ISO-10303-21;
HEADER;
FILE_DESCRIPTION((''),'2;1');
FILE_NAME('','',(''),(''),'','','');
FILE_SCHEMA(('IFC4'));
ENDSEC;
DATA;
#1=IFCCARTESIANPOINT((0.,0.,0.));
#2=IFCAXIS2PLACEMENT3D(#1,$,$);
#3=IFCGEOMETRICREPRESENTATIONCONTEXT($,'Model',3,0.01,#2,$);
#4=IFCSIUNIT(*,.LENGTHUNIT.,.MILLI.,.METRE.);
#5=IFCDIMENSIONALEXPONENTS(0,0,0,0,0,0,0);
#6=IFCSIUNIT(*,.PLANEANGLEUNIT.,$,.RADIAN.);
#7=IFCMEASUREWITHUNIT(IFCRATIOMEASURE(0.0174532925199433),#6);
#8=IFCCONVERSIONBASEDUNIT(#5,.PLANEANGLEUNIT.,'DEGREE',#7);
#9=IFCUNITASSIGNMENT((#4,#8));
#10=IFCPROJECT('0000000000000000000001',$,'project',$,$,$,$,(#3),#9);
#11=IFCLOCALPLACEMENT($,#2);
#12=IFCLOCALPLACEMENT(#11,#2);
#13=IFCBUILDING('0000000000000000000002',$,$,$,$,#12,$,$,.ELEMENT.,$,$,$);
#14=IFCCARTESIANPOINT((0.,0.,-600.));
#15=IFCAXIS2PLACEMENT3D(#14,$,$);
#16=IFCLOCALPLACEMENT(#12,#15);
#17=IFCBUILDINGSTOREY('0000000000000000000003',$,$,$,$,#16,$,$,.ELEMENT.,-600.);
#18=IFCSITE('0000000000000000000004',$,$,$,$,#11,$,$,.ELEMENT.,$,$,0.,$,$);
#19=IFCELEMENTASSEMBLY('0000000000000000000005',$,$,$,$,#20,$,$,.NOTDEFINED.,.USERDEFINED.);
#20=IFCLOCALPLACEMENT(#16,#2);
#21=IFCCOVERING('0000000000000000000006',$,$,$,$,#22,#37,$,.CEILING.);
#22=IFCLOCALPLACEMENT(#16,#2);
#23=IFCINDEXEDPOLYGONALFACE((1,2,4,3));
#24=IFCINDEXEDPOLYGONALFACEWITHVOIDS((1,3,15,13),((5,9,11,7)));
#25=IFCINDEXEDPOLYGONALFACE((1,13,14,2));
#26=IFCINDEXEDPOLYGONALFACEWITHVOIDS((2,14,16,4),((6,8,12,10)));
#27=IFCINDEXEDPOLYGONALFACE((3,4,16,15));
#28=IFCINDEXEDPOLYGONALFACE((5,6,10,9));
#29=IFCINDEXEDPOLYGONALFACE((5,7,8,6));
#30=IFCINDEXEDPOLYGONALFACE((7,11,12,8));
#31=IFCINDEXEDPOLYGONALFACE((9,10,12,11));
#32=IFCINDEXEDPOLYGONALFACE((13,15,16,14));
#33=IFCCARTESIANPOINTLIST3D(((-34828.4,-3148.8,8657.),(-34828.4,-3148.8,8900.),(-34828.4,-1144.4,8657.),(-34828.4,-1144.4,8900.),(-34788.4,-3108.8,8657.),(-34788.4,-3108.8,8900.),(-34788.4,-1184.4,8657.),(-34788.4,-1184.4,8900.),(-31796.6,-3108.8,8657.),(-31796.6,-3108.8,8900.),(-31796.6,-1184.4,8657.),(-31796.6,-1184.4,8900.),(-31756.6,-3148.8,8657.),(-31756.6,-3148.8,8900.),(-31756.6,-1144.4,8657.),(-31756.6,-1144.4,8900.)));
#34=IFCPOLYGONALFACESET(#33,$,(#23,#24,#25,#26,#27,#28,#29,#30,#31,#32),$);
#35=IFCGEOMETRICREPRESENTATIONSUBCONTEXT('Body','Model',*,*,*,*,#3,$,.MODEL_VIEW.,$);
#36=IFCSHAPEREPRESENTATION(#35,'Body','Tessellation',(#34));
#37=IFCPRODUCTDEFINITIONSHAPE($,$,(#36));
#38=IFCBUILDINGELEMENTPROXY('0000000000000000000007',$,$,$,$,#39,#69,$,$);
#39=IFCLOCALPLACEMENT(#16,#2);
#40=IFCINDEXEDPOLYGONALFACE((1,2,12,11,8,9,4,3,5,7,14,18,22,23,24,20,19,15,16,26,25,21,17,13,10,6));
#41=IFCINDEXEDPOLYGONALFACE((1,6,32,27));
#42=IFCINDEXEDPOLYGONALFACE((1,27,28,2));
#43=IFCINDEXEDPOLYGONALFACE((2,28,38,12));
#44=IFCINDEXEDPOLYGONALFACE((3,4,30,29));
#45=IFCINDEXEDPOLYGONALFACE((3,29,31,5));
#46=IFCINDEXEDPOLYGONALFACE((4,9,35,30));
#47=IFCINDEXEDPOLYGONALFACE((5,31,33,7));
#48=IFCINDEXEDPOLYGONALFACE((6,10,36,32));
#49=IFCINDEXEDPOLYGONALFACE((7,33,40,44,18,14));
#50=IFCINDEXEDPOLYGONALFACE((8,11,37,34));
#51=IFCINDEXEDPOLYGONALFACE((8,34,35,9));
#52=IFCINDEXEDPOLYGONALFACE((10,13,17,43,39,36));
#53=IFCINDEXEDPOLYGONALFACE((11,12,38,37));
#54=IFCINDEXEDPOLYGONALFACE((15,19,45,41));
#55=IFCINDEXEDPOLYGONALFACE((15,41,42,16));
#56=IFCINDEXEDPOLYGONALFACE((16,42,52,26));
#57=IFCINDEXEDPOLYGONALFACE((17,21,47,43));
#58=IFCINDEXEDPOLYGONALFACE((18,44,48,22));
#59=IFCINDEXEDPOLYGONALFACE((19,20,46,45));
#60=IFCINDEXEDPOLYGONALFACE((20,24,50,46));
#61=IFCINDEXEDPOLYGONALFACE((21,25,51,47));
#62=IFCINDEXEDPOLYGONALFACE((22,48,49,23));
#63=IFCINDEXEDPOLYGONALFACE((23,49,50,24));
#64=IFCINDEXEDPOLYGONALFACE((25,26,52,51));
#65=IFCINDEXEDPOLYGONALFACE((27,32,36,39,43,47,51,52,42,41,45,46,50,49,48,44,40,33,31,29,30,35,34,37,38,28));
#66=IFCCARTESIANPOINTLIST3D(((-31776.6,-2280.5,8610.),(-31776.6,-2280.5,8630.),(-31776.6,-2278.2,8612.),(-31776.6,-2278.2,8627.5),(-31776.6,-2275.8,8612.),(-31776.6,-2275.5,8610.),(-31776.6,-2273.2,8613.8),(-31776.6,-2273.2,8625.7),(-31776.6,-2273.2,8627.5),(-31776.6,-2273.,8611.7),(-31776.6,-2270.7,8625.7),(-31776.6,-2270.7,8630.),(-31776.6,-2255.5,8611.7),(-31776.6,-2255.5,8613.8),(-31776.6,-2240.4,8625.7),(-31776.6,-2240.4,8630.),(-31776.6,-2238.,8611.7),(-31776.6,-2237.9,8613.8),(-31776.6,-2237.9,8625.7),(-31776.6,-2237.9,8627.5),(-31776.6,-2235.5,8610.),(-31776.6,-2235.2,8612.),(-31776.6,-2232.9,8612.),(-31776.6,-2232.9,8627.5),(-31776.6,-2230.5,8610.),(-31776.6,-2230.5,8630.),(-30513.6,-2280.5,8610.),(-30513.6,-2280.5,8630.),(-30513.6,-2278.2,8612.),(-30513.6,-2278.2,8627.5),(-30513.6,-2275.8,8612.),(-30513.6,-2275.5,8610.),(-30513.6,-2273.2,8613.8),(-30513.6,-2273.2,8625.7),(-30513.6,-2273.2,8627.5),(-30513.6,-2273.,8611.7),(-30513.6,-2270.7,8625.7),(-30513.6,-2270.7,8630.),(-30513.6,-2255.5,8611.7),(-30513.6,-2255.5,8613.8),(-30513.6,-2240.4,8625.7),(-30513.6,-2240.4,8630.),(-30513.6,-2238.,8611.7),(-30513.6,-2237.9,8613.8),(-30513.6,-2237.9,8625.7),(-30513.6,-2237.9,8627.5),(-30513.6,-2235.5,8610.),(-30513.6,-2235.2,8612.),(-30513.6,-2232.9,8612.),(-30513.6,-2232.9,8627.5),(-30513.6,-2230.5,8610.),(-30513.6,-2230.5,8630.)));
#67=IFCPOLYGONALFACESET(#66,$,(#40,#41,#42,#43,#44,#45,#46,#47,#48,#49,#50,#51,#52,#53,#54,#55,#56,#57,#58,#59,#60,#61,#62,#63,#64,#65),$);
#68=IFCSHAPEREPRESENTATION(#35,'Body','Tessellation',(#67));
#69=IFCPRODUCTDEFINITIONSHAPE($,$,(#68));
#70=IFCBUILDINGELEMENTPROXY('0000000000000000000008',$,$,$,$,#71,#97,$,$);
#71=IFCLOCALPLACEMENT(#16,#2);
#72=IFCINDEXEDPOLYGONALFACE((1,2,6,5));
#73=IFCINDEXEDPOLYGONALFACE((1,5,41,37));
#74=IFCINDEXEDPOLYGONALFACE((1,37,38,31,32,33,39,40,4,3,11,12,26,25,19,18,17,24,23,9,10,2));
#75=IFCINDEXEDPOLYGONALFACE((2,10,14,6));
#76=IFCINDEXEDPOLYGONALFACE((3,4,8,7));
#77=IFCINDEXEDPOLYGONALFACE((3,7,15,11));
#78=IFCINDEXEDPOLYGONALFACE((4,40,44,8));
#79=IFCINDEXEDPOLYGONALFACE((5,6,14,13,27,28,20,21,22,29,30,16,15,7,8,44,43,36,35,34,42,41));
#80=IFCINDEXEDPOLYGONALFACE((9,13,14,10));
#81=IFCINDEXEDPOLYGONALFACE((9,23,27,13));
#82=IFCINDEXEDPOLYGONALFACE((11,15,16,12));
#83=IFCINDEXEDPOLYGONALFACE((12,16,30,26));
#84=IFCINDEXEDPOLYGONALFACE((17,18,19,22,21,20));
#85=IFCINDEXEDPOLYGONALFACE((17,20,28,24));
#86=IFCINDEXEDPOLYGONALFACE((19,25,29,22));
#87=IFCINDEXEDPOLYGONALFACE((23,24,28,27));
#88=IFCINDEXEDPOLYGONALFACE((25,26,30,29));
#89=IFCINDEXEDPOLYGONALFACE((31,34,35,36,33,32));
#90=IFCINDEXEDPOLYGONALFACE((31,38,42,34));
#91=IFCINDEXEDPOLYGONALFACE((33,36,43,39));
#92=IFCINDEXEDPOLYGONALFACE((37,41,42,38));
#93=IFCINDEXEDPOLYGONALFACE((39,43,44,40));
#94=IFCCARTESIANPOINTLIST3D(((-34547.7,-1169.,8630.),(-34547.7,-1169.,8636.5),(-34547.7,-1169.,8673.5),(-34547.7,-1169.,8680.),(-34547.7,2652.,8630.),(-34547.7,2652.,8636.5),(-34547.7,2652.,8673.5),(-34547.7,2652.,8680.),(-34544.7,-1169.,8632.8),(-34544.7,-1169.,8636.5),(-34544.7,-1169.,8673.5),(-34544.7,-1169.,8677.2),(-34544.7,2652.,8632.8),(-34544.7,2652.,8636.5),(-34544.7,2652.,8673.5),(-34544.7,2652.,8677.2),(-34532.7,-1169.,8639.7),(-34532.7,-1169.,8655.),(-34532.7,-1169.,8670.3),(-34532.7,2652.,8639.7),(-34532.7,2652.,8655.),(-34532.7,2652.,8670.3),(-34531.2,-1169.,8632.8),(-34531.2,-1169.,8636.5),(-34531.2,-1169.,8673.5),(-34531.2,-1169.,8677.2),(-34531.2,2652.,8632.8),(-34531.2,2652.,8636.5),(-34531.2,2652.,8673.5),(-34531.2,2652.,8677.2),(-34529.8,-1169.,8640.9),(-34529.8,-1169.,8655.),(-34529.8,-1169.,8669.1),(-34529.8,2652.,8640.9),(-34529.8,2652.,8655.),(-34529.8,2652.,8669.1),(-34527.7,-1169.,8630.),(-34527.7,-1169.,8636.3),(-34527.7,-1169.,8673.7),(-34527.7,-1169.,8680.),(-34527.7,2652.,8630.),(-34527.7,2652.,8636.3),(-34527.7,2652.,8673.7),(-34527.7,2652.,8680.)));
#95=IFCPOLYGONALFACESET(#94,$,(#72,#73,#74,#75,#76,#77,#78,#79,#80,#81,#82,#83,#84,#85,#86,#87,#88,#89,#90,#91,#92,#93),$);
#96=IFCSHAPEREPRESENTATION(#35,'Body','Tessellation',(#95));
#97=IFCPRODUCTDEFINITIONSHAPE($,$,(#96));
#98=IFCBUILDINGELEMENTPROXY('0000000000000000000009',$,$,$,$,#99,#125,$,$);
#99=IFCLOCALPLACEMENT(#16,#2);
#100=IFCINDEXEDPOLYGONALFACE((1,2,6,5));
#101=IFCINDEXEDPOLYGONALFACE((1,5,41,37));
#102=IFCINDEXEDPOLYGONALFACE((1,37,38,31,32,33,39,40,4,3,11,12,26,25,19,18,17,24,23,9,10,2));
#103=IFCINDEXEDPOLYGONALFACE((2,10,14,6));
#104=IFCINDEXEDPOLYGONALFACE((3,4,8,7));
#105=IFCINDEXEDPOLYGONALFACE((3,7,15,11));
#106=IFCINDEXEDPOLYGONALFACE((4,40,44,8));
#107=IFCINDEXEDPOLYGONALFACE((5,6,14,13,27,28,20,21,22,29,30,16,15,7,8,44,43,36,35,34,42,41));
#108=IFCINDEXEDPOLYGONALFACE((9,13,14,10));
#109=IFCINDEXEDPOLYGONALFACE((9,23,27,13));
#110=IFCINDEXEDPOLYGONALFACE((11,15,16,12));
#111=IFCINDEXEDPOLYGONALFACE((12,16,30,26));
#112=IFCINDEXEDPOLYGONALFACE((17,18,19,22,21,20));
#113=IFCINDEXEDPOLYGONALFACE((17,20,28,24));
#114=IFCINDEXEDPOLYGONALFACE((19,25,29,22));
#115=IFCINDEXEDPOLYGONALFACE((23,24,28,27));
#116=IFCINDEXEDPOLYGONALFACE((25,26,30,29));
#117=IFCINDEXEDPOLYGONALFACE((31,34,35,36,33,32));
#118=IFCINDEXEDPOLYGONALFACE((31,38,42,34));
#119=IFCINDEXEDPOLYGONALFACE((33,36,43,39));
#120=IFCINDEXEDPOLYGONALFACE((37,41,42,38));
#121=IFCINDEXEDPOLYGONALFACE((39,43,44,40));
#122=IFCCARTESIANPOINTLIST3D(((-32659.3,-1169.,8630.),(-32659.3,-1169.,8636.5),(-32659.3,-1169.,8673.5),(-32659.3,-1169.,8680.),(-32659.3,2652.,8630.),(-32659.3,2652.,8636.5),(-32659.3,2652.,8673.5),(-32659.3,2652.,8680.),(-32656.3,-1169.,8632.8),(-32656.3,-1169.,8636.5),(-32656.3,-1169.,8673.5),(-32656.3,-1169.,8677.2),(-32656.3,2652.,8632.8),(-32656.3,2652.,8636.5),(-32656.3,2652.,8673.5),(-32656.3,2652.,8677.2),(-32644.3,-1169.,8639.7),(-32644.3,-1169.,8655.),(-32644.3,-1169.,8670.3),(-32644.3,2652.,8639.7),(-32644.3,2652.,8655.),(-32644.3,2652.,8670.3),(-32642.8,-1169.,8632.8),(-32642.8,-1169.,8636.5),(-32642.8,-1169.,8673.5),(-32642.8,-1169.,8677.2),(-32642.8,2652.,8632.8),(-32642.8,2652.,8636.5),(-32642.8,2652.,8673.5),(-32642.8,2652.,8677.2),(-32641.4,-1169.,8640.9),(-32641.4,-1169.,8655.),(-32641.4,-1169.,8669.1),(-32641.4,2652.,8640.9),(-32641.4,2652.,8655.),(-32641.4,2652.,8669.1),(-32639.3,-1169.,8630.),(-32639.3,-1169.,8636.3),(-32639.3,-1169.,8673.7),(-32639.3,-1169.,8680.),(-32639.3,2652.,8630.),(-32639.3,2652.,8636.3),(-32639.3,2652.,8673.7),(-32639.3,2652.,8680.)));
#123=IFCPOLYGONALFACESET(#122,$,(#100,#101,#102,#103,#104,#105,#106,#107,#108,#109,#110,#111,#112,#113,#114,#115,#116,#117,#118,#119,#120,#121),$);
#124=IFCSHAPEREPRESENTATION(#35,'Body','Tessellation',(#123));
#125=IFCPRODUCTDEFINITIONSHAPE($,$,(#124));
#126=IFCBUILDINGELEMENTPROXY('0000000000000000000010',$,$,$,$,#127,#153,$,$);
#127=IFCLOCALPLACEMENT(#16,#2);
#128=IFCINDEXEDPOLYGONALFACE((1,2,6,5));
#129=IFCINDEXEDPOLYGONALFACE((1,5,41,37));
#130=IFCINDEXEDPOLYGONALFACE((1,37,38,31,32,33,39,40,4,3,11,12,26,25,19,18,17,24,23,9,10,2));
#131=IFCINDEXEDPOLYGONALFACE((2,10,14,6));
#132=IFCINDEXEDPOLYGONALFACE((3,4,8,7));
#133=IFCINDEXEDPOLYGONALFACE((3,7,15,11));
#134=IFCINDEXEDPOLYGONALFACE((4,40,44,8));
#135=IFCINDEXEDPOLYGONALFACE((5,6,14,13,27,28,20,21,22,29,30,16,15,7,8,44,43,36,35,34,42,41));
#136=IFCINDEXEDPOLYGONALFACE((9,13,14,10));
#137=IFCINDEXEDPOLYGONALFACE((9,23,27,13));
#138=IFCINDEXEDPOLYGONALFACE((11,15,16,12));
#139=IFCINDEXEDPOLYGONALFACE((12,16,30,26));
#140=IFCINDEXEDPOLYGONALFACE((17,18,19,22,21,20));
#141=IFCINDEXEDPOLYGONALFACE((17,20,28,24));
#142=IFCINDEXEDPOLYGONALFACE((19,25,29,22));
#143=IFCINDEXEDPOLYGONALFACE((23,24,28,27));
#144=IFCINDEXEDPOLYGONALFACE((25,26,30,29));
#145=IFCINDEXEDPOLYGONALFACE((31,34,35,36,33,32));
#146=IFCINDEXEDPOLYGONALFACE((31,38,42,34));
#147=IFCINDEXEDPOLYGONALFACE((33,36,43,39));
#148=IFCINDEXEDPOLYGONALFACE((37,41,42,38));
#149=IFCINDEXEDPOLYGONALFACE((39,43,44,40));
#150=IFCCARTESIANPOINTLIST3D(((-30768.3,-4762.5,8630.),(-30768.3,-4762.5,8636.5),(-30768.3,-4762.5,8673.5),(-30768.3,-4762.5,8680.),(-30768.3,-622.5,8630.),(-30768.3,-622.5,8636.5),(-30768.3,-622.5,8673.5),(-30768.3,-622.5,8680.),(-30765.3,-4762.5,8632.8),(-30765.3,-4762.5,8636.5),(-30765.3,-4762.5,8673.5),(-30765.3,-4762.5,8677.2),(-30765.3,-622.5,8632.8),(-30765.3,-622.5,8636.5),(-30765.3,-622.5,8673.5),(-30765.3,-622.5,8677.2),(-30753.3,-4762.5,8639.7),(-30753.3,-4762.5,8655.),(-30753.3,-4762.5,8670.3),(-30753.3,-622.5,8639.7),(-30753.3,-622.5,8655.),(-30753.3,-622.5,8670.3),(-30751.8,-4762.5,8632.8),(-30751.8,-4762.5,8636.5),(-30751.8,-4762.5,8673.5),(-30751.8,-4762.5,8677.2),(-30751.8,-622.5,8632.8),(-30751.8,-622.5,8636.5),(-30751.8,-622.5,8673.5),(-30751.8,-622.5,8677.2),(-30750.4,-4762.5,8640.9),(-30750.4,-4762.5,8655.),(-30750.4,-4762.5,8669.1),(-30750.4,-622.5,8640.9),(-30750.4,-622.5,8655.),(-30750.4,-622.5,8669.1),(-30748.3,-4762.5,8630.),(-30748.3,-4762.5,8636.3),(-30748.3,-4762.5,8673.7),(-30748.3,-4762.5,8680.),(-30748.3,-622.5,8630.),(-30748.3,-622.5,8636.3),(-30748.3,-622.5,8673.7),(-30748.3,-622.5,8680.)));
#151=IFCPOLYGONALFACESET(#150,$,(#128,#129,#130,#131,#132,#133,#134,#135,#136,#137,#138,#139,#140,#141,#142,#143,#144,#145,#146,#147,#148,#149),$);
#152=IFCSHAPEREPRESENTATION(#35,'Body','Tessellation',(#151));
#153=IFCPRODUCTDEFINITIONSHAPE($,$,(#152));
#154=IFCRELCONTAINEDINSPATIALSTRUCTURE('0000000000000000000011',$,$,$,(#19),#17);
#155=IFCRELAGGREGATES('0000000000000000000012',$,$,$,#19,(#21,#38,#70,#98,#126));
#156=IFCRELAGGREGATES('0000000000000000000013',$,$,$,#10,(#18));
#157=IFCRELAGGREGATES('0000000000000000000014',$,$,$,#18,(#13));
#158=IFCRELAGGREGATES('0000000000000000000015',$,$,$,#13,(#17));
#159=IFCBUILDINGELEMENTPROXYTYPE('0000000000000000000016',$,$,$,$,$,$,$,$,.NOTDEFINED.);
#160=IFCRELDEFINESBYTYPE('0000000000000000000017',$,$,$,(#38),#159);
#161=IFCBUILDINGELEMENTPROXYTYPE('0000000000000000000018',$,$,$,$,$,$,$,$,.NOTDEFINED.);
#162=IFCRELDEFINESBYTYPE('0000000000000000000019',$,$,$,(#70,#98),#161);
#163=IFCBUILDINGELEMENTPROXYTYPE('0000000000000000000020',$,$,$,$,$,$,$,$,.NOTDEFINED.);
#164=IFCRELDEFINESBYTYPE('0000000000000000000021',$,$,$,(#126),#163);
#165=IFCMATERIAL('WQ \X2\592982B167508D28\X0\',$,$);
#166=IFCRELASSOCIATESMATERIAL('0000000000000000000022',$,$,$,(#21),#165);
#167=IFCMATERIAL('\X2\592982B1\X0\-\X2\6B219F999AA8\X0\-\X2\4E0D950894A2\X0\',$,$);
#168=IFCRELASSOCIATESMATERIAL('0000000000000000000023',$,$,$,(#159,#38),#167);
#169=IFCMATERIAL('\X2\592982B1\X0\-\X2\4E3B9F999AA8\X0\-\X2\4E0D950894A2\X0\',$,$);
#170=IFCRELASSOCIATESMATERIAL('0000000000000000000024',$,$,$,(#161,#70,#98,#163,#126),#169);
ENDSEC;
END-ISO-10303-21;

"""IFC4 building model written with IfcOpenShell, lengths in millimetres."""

from ifc_helpers import new_model, entity, si_unit, converted_unit, frame, origin, place, context, subcontext, project, spatial, polyline, outline, extrude, source, transform, mapped, material, type_object, type_shapes, element, aggregate, save


model = new_model("IFC4")

# Units and contexts
model_context = context("Model", 3, precision=0.01, world=origin())
body_context = subcontext(model_context, "Body", "Model", "MODEL_VIEW")
ifc_project = project(units=[si_unit("LENGTHUNIT", "METRE", prefix="MILLI"), converted_unit("PLANEANGLEUNIT", "DEGREE", entity("IfcRatioMeasure", 0.0174532925199433), si_unit("PLANEANGLEUNIT", "RADIAN"), dimensions=[0, 0, 0, 0, 0, 0, 0])], contexts=[model_context])

# Site, building, storey
site_placement = place(None, origin())
site = spatial("IfcSite", under=ifc_project, at=site_placement, CompositionType="ELEMENT", RefElevation=0.0)
building_placement = place(site_placement, origin())
building = spatial("IfcBuilding", under=site, at=building_placement, CompositionType="ELEMENT")
storey_placement = place(building_placement, frame((0.0, 0.0, -600.0)))
storey = spatial("IfcBuildingStorey", under=building, at=storey_placement, CompositionType="ELEMENT", Elevation=-600.0)

# Element assembly, covering, building element proxies
assembly_placement = place(storey_placement, origin())
assembly = element("IfcElementAssembly", 1, at=assembly_placement, inside=storey, AssemblyPlace="NOTDEFINED", PredefinedType="USERDEFINED")
ifc_material_1 = material(Name="WQ 天花材质")
covering_1_placement = place(assembly_placement, frame((-34828.4, -3148.8, 8657.0)))
covering_1 = element("IfcCovering", 2, at=covering_1_placement, material=ifc_material_1, PredefinedType="CEILING", context=body_context, shape_type="SweptSolid", body=[
    extrude(outline(polyline([(-1535.9, -1002.2), (1535.9, -1002.2), (1535.9, 1002.2), (-1535.9, 1002.2), (-1535.9, -1002.2)]), holes=[polyline([(-1495.9, -962.2), (-1495.9, 962.2), (1495.9, 962.2), (1495.9, -962.2), (-1495.9, -962.2)])]), frame((1535.9, 1002.2, 0.0), z_axis=(0.0, 0.0, 1.0), x_axis=(-1.0, 0.0, 0.0)), (0.0, 0.0, 1.0), 243.0),
])
ifc_material_2 = material(Name="天花-次龙骨-不锈钢")
building_element_proxy_type_1 = type_object("IfcBuildingElementProxyType", PredefinedType="NOTDEFINED", material=ifc_material_2)
shared_shape_1 = source(origin(), body_context, "Body", "SweptSolid", [
    extrude(outline(polyline([(-25.0, -9.1), (-20.0, -9.1), (-17.5, -7.4), (0.0, -7.4), (17.5, -7.4), (20.0, -9.1), (25.0, -9.1), (25.0, 10.9), (15.1, 10.9), (15.1, 6.6), (17.6, 6.6), (17.6, 8.4), (22.6, 8.4), (22.6, -7.1), (20.3, -7.1), (17.6, -5.3), (0.0, -5.3), (-17.6, -5.3), (-20.3, -7.1), (-22.6, -7.1), (-22.6, 8.4), (-17.6, 8.4), (-17.6, 6.6), (-15.1, 6.6), (-15.1, 10.9), (-25.0, 10.9), (-25.0, -9.1)])), frame((0.0, 0.0, -0.9), z_axis=(1.0, 0.0, 0.0), x_axis=(0.0, 1.0, 0.0)), (0.0, 0.0, 1.0), 1263.0),
])
type_shapes(building_element_proxy_type_1, [shared_shape_1])
proxy_1_placement = place(assembly_placement, frame((-31776.6, -2255.5, 8620.0)))
proxy_1 = element("IfcBuildingElementProxy", 3, at=proxy_1_placement, type_object=building_element_proxy_type_1, material=ifc_material_2, context=body_context, shape_type="MappedRepresentation", body=[
    mapped(shared_shape_1, transform((0.0, 0.0, 0.0), scale=1.0)),
])
ifc_material_3 = material(Name="天花-主龙骨-不锈钢")
building_element_proxy_type_2 = type_object("IfcBuildingElementProxyType", PredefinedType="NOTDEFINED", material=ifc_material_3)
shared_shape_2 = source(origin(), body_context, "Body", "SweptSolid", [
    extrude(outline(polyline([(-25.0, -11.7), (-18.5, -11.7), (-18.5, -8.7), (-22.2, -8.7), (-22.2, 4.8), (-18.5, 4.8), (-15.3, 3.3), (0.0, 3.3), (15.3, 3.3), (18.5, 4.8), (22.2, 4.8), (22.2, -8.7), (18.5, -8.7), (18.5, -11.7), (25.0, -11.7), (25.0, 8.3), (18.7, 8.3), (14.1, 6.2), (0.0, 6.2), (-14.1, 6.2), (-18.7, 8.3), (-25.0, 8.3), (-25.0, -11.7)])), frame((0.0, 1.7, 0.0), z_axis=(1.0, 0.0, 0.0), x_axis=(0.0, 0.0, -1.0)), (0.0, 0.0, 1.0), 3821.0),
])
type_shapes(building_element_proxy_type_2, [shared_shape_2])
proxy_2_placement = place(assembly_placement, frame((-34537.7, 2652.0, 8655.0), z_axis=(0.0, 0.0, 1.0), x_axis=(0.0, -1.0, 0.0)))
proxy_2 = element("IfcBuildingElementProxy", 4, at=proxy_2_placement, type_object=building_element_proxy_type_2, material=ifc_material_3, context=body_context, shape_type="MappedRepresentation", body=[
    mapped(shared_shape_2, transform((0.0, 0.0, 0.0), scale=1.0)),
])
proxy_3_placement = place(assembly_placement, frame((-32649.3, 2652.0, 8655.0), z_axis=(0.0, 0.0, 1.0), x_axis=(0.0, -1.0, 0.0)))
proxy_3 = element("IfcBuildingElementProxy", 5, at=proxy_3_placement, type_object=building_element_proxy_type_2, material=ifc_material_3, context=body_context, shape_type="MappedRepresentation", body=[
    mapped(shared_shape_2, transform((0.0, 0.0, 0.0), scale=1.0)),
])
building_element_proxy_type_3 = type_object("IfcBuildingElementProxyType", PredefinedType="NOTDEFINED", material=ifc_material_3)
shared_shape_3 = source(origin(), body_context, "Body", "SweptSolid", [
    extrude(outline(polyline([(-25.0, -11.7), (-18.5, -11.7), (-18.5, -8.7), (-22.2, -8.7), (-22.2, 4.8), (-18.5, 4.8), (-15.3, 3.3), (0.0, 3.3), (15.3, 3.3), (18.5, 4.8), (22.2, 4.8), (22.2, -8.7), (18.5, -8.7), (18.5, -11.7), (25.0, -11.7), (25.0, 8.3), (18.7, 8.3), (14.1, 6.2), (0.0, 6.2), (-14.1, 6.2), (-18.7, 8.3), (-25.0, 8.3), (-25.0, -11.7)])), frame((0.0, 1.7, 0.0), z_axis=(1.0, 0.0, 0.0), x_axis=(0.0, 0.0, -1.0)), (0.0, 0.0, 1.0), 4140.0),
])
type_shapes(building_element_proxy_type_3, [shared_shape_3])
proxy_4_placement = place(assembly_placement, frame((-30758.3, -622.5, 8655.0), z_axis=(0.0, 0.0, 1.0), x_axis=(0.0, -1.0, 0.0)))
proxy_4 = element("IfcBuildingElementProxy", 6, at=proxy_4_placement, type_object=building_element_proxy_type_3, material=ifc_material_3, context=body_context, shape_type="MappedRepresentation", body=[
    mapped(shared_shape_3, transform((0.0, 0.0, 0.0), scale=1.0)),
])
aggregate(assembly, [covering_1, proxy_1, proxy_2, proxy_3, proxy_4])

save(model, "model.ifc")
